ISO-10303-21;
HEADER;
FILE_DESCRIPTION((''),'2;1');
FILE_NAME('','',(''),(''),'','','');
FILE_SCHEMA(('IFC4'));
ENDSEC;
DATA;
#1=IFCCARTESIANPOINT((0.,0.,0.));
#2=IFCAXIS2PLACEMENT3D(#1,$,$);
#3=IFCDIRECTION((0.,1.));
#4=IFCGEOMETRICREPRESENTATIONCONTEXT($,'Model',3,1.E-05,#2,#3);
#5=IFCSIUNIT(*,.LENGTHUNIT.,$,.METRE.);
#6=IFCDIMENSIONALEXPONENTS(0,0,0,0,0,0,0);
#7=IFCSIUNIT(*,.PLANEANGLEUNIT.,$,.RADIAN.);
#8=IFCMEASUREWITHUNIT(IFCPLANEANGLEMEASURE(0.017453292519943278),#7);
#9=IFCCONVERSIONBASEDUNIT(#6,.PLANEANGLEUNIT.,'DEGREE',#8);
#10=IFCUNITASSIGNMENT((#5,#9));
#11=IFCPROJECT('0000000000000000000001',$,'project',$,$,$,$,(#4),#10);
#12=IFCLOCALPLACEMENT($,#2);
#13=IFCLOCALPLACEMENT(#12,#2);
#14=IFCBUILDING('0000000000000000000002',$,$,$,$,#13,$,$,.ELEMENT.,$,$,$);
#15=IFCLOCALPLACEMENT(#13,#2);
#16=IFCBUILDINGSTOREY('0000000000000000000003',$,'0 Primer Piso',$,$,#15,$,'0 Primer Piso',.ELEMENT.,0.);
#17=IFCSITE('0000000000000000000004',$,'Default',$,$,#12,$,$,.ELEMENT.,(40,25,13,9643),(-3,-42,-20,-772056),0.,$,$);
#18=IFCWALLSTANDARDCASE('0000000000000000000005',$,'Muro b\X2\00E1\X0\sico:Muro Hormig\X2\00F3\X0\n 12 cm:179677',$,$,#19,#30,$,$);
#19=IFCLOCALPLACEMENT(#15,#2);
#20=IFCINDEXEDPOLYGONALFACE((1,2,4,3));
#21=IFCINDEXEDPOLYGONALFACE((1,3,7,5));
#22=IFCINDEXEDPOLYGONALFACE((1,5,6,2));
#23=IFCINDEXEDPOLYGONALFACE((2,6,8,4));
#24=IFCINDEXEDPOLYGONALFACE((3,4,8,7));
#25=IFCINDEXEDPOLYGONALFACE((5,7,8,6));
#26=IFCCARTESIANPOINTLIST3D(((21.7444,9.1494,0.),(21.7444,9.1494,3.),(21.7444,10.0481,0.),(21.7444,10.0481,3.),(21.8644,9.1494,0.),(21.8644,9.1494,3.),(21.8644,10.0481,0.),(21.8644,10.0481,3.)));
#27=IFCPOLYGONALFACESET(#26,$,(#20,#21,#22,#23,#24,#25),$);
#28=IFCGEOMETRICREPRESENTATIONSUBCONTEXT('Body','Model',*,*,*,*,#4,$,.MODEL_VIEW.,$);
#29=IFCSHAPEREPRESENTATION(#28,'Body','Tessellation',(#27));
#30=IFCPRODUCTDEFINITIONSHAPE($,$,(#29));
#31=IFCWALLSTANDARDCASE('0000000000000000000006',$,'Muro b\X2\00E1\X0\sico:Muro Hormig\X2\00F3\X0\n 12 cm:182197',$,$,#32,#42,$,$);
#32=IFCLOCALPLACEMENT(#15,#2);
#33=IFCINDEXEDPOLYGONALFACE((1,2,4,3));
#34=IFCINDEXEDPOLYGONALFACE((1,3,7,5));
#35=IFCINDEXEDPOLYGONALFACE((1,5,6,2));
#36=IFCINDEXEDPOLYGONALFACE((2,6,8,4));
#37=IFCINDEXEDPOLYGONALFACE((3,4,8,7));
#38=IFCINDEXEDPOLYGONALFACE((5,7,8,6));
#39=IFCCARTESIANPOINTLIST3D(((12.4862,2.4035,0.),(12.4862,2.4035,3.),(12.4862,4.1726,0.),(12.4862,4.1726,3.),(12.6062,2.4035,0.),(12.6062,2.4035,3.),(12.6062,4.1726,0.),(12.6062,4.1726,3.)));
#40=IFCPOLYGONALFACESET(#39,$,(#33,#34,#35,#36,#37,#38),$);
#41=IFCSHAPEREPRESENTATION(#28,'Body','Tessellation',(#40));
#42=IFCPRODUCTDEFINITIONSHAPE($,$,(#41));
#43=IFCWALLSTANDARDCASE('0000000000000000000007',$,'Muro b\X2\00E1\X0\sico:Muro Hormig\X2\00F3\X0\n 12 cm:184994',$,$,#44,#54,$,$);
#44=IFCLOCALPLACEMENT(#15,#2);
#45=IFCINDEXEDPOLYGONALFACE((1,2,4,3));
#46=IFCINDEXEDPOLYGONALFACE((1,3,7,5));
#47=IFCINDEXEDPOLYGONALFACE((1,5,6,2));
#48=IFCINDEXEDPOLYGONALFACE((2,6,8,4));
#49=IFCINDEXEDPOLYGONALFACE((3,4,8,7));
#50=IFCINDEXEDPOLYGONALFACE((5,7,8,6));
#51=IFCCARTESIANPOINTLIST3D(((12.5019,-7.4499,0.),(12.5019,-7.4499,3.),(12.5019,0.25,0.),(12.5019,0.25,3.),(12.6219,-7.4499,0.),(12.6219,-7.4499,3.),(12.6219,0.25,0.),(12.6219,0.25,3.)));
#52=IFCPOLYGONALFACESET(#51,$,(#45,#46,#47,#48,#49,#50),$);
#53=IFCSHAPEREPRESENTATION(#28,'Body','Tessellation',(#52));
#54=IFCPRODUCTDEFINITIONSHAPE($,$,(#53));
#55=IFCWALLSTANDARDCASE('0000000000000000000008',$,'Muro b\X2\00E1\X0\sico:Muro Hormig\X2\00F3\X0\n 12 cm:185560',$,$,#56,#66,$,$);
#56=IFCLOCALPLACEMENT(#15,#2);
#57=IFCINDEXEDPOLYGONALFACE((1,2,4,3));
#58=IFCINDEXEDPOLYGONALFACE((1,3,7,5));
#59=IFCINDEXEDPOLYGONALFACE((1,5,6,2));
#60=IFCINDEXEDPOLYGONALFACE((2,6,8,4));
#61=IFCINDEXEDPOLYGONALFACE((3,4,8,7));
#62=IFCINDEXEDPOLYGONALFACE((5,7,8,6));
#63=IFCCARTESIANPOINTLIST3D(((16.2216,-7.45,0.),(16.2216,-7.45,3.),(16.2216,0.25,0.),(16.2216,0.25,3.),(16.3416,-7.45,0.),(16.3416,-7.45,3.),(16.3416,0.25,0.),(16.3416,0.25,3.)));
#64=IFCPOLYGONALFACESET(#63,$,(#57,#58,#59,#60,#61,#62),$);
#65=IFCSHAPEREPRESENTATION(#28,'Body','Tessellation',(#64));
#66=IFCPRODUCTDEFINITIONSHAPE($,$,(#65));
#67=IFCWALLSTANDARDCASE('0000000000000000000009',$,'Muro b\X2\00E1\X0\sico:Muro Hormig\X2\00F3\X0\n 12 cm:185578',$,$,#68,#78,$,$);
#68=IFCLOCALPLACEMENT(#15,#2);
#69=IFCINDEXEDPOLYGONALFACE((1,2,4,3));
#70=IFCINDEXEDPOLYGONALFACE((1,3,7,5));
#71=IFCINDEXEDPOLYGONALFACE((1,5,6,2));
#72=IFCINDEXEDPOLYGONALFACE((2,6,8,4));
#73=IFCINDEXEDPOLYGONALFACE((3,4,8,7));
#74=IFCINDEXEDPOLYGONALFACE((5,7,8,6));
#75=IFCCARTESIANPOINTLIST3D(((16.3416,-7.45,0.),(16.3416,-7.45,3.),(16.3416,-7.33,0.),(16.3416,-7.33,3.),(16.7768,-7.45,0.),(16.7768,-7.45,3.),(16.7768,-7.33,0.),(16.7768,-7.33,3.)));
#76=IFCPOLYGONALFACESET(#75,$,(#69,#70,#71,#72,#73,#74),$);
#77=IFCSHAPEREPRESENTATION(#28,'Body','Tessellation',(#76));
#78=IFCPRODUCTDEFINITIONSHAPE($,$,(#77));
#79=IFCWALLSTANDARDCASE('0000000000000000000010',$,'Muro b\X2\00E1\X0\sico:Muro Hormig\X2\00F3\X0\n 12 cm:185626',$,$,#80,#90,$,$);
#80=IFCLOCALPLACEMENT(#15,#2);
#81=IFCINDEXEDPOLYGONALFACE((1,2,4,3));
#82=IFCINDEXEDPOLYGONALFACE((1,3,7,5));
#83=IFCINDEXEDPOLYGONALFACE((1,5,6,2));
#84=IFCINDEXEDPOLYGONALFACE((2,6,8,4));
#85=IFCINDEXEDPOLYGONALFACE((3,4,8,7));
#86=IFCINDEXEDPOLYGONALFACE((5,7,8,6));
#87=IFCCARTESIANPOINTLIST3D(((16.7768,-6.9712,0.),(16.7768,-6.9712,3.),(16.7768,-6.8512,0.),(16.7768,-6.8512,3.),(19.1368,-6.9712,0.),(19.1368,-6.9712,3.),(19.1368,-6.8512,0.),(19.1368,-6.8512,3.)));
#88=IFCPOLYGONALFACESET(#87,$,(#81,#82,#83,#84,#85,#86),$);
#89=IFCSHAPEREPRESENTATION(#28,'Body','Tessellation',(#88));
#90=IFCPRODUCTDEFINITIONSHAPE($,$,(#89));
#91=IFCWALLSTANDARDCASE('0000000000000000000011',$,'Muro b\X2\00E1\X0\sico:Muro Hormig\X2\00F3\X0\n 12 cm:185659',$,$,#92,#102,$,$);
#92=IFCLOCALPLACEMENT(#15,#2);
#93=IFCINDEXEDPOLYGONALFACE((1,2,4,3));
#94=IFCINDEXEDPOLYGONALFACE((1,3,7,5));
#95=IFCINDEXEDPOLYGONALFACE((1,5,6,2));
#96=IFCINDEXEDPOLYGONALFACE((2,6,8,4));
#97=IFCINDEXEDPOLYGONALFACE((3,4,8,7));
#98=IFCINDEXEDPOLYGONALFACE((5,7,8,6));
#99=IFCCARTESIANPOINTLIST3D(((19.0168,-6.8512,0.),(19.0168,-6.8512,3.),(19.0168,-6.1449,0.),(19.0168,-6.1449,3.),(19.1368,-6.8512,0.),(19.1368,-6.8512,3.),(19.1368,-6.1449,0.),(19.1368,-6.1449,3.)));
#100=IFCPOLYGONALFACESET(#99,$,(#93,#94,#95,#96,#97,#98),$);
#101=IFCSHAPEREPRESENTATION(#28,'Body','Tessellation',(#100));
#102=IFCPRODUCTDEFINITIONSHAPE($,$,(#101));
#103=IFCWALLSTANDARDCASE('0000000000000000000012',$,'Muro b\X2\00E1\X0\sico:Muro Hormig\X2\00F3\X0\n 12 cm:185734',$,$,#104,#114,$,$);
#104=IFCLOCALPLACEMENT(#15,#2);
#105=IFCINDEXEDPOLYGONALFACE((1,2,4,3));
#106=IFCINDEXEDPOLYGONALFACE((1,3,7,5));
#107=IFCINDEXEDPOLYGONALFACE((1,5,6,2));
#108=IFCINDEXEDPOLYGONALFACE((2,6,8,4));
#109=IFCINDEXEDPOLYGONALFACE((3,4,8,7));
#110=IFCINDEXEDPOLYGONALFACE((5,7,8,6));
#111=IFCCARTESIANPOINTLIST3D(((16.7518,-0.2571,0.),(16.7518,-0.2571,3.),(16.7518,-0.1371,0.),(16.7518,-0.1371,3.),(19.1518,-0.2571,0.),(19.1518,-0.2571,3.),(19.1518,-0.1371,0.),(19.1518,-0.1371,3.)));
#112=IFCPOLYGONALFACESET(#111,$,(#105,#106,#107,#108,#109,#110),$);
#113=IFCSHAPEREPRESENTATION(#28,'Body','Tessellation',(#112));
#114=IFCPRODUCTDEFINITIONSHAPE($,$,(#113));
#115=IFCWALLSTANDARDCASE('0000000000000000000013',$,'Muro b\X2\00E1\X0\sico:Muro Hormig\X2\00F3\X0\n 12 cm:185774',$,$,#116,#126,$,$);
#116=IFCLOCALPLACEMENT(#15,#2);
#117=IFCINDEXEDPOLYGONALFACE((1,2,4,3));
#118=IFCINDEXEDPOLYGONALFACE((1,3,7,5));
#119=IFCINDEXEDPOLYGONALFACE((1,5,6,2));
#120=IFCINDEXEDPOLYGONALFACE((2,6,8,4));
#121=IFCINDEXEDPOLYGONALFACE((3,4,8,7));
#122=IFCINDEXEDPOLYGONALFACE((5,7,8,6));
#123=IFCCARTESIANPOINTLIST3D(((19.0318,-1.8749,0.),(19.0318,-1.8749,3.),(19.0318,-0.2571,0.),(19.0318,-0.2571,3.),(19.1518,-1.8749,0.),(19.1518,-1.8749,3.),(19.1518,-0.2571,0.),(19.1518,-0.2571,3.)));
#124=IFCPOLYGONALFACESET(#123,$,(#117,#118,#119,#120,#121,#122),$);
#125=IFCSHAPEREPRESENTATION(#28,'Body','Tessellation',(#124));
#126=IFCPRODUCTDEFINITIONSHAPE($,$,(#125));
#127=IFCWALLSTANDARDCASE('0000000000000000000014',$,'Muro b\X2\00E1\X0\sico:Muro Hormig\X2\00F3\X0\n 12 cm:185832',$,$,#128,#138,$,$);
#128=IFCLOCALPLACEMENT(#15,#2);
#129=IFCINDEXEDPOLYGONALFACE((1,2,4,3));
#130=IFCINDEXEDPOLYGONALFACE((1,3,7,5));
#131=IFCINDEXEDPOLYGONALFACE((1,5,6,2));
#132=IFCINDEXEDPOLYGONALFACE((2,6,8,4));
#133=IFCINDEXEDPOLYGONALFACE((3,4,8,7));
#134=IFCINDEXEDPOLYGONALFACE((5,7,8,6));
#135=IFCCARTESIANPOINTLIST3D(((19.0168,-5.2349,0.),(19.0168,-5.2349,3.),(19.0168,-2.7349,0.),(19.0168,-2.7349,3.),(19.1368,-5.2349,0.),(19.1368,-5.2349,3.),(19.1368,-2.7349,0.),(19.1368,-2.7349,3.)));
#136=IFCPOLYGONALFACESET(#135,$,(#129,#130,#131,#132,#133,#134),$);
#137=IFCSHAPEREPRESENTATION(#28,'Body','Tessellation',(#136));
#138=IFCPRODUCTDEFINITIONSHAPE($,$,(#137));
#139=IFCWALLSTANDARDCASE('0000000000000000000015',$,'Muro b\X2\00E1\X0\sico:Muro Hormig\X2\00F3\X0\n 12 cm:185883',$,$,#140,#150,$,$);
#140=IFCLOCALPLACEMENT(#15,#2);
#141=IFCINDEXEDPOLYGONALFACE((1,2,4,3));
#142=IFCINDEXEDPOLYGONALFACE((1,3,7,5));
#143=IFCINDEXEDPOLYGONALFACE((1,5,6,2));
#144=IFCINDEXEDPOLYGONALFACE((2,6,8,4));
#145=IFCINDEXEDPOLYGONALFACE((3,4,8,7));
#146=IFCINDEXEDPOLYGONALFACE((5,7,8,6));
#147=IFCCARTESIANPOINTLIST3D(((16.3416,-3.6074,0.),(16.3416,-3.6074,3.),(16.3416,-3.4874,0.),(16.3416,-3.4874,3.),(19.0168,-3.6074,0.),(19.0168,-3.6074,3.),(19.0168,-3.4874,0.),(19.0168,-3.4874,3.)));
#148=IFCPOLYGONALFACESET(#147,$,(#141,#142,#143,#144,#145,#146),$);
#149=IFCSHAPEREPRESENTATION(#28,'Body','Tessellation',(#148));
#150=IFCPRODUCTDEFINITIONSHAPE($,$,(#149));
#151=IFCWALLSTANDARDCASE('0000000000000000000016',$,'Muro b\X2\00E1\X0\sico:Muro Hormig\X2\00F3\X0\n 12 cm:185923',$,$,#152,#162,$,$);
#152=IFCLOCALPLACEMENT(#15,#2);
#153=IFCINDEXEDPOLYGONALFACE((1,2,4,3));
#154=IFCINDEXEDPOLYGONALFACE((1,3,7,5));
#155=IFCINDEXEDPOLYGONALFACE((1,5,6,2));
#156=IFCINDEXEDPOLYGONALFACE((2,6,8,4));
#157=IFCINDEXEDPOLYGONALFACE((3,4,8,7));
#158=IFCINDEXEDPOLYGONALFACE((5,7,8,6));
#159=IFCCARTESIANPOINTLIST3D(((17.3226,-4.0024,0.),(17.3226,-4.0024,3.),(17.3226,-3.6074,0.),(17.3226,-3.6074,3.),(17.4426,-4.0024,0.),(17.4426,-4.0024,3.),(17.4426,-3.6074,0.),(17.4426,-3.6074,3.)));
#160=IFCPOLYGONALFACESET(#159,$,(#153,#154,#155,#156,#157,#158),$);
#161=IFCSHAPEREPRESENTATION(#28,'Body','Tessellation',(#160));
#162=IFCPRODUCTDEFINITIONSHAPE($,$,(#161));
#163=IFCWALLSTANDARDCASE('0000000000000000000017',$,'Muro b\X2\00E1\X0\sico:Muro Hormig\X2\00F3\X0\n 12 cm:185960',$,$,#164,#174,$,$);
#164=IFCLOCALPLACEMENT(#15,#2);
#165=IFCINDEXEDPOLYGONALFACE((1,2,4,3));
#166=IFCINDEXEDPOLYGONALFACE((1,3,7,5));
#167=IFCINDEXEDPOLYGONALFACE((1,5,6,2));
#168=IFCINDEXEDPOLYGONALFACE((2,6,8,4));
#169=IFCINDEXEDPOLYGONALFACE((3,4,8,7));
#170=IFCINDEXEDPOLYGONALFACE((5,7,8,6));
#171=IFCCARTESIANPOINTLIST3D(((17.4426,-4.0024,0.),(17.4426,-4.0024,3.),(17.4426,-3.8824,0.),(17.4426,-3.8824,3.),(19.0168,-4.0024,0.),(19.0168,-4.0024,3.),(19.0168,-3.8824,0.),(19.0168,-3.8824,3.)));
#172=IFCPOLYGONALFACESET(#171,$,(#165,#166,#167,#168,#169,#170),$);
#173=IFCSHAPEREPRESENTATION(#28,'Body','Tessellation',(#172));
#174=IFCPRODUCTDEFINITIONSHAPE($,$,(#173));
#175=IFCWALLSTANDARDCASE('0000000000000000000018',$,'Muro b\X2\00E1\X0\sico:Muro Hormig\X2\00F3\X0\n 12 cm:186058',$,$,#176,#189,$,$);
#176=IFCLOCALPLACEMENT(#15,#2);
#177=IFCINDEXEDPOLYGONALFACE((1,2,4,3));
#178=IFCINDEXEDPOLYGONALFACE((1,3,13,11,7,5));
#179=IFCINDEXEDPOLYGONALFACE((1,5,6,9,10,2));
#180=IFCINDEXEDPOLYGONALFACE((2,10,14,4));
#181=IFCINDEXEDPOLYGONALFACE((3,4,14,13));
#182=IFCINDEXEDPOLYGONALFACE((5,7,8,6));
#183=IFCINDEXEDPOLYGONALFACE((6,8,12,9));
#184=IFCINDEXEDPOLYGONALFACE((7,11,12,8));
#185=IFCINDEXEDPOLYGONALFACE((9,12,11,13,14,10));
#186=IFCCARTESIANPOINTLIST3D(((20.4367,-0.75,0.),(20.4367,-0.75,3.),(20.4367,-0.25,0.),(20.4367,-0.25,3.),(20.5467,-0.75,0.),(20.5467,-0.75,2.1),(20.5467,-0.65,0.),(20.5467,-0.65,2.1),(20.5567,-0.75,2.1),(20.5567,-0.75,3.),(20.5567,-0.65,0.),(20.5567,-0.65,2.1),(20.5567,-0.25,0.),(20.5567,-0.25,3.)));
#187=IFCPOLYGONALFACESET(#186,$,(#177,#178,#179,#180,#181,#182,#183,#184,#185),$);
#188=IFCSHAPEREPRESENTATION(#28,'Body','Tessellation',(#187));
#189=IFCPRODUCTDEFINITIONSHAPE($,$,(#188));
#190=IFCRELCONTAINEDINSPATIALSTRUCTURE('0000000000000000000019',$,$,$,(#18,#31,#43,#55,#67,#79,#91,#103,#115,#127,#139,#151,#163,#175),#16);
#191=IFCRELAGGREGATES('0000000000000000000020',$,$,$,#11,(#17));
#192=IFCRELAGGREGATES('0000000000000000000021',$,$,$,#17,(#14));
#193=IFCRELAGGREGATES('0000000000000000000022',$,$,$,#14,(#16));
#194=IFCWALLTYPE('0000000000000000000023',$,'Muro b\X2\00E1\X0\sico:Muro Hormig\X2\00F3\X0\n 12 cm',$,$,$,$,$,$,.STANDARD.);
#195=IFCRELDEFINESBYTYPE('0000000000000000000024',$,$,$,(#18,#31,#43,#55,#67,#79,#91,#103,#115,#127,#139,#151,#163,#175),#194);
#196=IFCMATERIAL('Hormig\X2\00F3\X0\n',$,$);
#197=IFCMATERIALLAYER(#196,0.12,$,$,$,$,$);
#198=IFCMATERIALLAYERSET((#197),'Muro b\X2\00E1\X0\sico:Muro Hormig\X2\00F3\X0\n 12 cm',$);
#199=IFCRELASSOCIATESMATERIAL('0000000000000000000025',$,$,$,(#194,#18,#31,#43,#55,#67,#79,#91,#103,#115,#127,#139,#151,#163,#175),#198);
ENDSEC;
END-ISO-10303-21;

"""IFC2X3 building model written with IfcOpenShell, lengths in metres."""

from ifc_helpers import new_model, entity, si_unit, converted_unit, direction, frame, frame_2d, origin, place, context, subcontext, project, spatial, rectangle, extrude, material, layer, layer_set, layer_usage, type_object, element, save


model = new_model("IFC2X3")

# Units and contexts
model_context = context("Model", 3, precision=1e-05, world=origin(), true_north=direction((0.0, 1.0)))
body_context = subcontext(model_context, "Body", "Model", "MODEL_VIEW")
ifc_project = project(units=[si_unit("LENGTHUNIT", "METRE"), converted_unit("PLANEANGLEUNIT", "DEGREE", entity("IfcPlaneAngleMeasure", 0.017453292519943278), si_unit("PLANEANGLEUNIT", "RADIAN"), dimensions=[0, 0, 0, 0, 0, 0, 0])], contexts=[model_context])

# Site, building, storey
site_placement = place(None, origin())
site = spatial("IfcSite", under=ifc_project, at=site_placement, Name="Default", CompositionType="ELEMENT", RefLatitude=(40, 25, 13, 9643), RefLongitude=(-3, -42, -20, -772056), RefElevation=0.0)
building_placement = place(site_placement, origin())
building = spatial("IfcBuilding", under=site, at=building_placement, CompositionType="ELEMENT")
storey_placement = place(building_placement, origin())
storey = spatial("IfcBuildingStorey", under=building, at=storey_placement, Name="0 Primer Piso", LongName="0 Primer Piso", CompositionType="ELEMENT", Elevation=0.0)

# Walls
ifc_material = material(Name="Hormigón")
ifc_layer = layer(ifc_material, 0.12)
ifc_layer_set = layer_set([ifc_layer], Name="Muro básico:Muro Hormigón 12 cm")
ifc_layer_usage_1 = layer_usage(ifc_layer_set, "AXIS2", "NEGATIVE", 0.06)
wall_type = type_object("IfcWallType", Name="Muro básico:Muro Hormigón 12 cm", PredefinedType="STANDARD", material=ifc_layer_set)
wall_1_placement = place(storey_placement, frame((21.8044, 9.1494, 0.0), z_axis=(0.0, 0.0, 1.0), x_axis=(0.0, 1.0, 0.0)))
element("IfcWallStandardCase", 1, at=wall_1_placement, inside=storey, type_object=wall_type, material=ifc_layer_usage_1, Name="Muro básico:Muro Hormigón 12 cm:179677", context=body_context, shape_type="SweptSolid", body=[
    extrude(rectangle(XDim=0.8988, YDim=0.12, at=frame_2d((0.4494, 0.0), x_axis=(-1.0, 0.0))), origin(), (0.0, 0.0, 1.0), 3.0),
])
ifc_layer_usage_2 = layer_usage(ifc_layer_set, "AXIS2", "NEGATIVE", 0.06)
wall_2_placement = place(storey_placement, frame((12.5462, 4.1726, 0.0), z_axis=(0.0, 0.0, 1.0), x_axis=(0.0, -1.0, 0.0)))
element("IfcWallStandardCase", 2, at=wall_2_placement, inside=storey, type_object=wall_type, material=ifc_layer_usage_2, Name="Muro básico:Muro Hormigón 12 cm:182197", context=body_context, shape_type="SweptSolid", body=[
    extrude(rectangle(XDim=1.7691, YDim=0.12, at=frame_2d((0.8846, 0.0), x_axis=(-1.0, 0.0))), origin(), (0.0, 0.0, 1.0), 3.0),
])
ifc_layer_usage_3 = layer_usage(ifc_layer_set, "AXIS2", "NEGATIVE", 0.06)
wall_3_placement = place(storey_placement, frame((12.5619, 0.25, 0.0), z_axis=(0.0, 0.0, 1.0), x_axis=(0.0, -1.0, 0.0)))
element("IfcWallStandardCase", 3, at=wall_3_placement, inside=storey, type_object=wall_type, material=ifc_layer_usage_3, Name="Muro básico:Muro Hormigón 12 cm:184994", context=body_context, shape_type="SweptSolid", body=[
    extrude(rectangle(XDim=7.6999, YDim=0.12, at=frame_2d((3.85, 0.0), x_axis=(-1.0, 0.0))), origin(), (0.0, 0.0, 1.0), 3.0),
])
ifc_layer_usage_4 = layer_usage(ifc_layer_set, "AXIS2", "NEGATIVE", 0.06)
wall_4_placement = place(storey_placement, frame((16.2816, 0.25, 0.0), z_axis=(0.0, 0.0, 1.0), x_axis=(0.0, -1.0, 0.0)))
element("IfcWallStandardCase", 4, at=wall_4_placement, inside=storey, type_object=wall_type, material=ifc_layer_usage_4, Name="Muro básico:Muro Hormigón 12 cm:185560", context=body_context, shape_type="SweptSolid", body=[
    extrude(rectangle(XDim=7.7, YDim=0.12, at=frame_2d((3.85, 0.0), x_axis=(-1.0, 0.0))), origin(), (0.0, 0.0, 1.0), 3.0),
])
ifc_layer_usage_5 = layer_usage(ifc_layer_set, "AXIS2", "NEGATIVE", 0.06)
wall_5_placement = place(storey_placement, frame((16.3416, -7.39, 0.0)))
element("IfcWallStandardCase", 5, at=wall_5_placement, inside=storey, type_object=wall_type, material=ifc_layer_usage_5, Name="Muro básico:Muro Hormigón 12 cm:185578", context=body_context, shape_type="SweptSolid", body=[
    extrude(rectangle(XDim=0.4351, YDim=0.12, at=frame_2d((0.2176, 0.0), x_axis=(-1.0, 0.0))), origin(), (0.0, 0.0, 1.0), 3.0),
])
ifc_layer_usage_6 = layer_usage(ifc_layer_set, "AXIS2", "NEGATIVE", 0.06)
wall_6_placement = place(storey_placement, frame((16.7768, -6.9112, 0.0)))
element("IfcWallStandardCase", 6, at=wall_6_placement, inside=storey, type_object=wall_type, material=ifc_layer_usage_6, Name="Muro básico:Muro Hormigón 12 cm:185626", context=body_context, shape_type="SweptSolid", body=[
    extrude(rectangle(XDim=2.36, YDim=0.12, at=frame_2d((1.18, 0.0), x_axis=(-1.0, 0.0))), origin(), (0.0, 0.0, 1.0), 3.0),
])
ifc_layer_usage_7 = layer_usage(ifc_layer_set, "AXIS2", "NEGATIVE", 0.06)
wall_7_placement = place(storey_placement, frame((19.0768, -6.8512, 0.0), z_axis=(0.0, 0.0, 1.0), x_axis=(0.0, 1.0, 0.0)))
element("IfcWallStandardCase", 7, at=wall_7_placement, inside=storey, type_object=wall_type, material=ifc_layer_usage_7, Name="Muro básico:Muro Hormigón 12 cm:185659", context=body_context, shape_type="SweptSolid", body=[
    extrude(rectangle(XDim=0.7063, YDim=0.12, at=frame_2d((0.3531, 0.0), x_axis=(-1.0, 0.0))), origin(), (0.0, 0.0, 1.0), 3.0),
])
ifc_layer_usage_8 = layer_usage(ifc_layer_set, "AXIS2", "NEGATIVE", 0.06)
wall_8_placement = place(storey_placement, frame((16.7518, -0.1971, 0.0)))
element("IfcWallStandardCase", 8, at=wall_8_placement, inside=storey, type_object=wall_type, material=ifc_layer_usage_8, Name="Muro básico:Muro Hormigón 12 cm:185734", context=body_context, shape_type="SweptSolid", body=[
    extrude(rectangle(XDim=2.4, YDim=0.12, at=frame_2d((1.2, 0.0), x_axis=(-1.0, 0.0))), origin(), (0.0, 0.0, 1.0), 3.0),
])
ifc_layer_usage_9 = layer_usage(ifc_layer_set, "AXIS2", "NEGATIVE", 0.06)
wall_9_placement = place(storey_placement, frame((19.0918, -0.2571, 0.0), z_axis=(0.0, 0.0, 1.0), x_axis=(0.0, -1.0, 0.0)))
element("IfcWallStandardCase", 9, at=wall_9_placement, inside=storey, type_object=wall_type, material=ifc_layer_usage_9, Name="Muro básico:Muro Hormigón 12 cm:185774", context=body_context, shape_type="SweptSolid", body=[
    extrude(rectangle(XDim=1.6178, YDim=0.12, at=frame_2d((0.8089, 0.0), x_axis=(-1.0, 0.0))), origin(), (0.0, 0.0, 1.0), 3.0),
])
ifc_layer_usage_10 = layer_usage(ifc_layer_set, "AXIS2", "NEGATIVE", 0.06)
wall_10_placement = place(storey_placement, frame((19.0768, -2.7349, 0.0), z_axis=(0.0, 0.0, 1.0), x_axis=(0.0, -1.0, 0.0)))
element("IfcWallStandardCase", 10, at=wall_10_placement, inside=storey, type_object=wall_type, material=ifc_layer_usage_10, Name="Muro básico:Muro Hormigón 12 cm:185832", context=body_context, shape_type="SweptSolid", body=[
    extrude(rectangle(XDim=2.5, YDim=0.12, at=frame_2d((1.25, 0.0), x_axis=(-1.0, 0.0))), origin(), (0.0, 0.0, 1.0), 3.0),
])
ifc_layer_usage_11 = layer_usage(ifc_layer_set, "AXIS2", "NEGATIVE", 0.06)
wall_11_placement = place(storey_placement, frame((19.0168, -3.5474, 0.0), z_axis=(0.0, 0.0, 1.0), x_axis=(-1.0, 0.0, 0.0)))
element("IfcWallStandardCase", 11, at=wall_11_placement, inside=storey, type_object=wall_type, material=ifc_layer_usage_11, Name="Muro básico:Muro Hormigón 12 cm:185883", context=body_context, shape_type="SweptSolid", body=[
    extrude(rectangle(XDim=2.6751, YDim=0.12, at=frame_2d((1.3376, 0.0), x_axis=(-1.0, 0.0))), origin(), (0.0, 0.0, 1.0), 3.0),
])
ifc_layer_usage_12 = layer_usage(ifc_layer_set, "AXIS2", "NEGATIVE", 0.06)
wall_12_placement = place(storey_placement, frame((17.3826, -3.6074, 0.0), z_axis=(0.0, 0.0, 1.0), x_axis=(0.0, -1.0, 0.0)))
element("IfcWallStandardCase", 12, at=wall_12_placement, inside=storey, type_object=wall_type, material=ifc_layer_usage_12, Name="Muro básico:Muro Hormigón 12 cm:185923", context=body_context, shape_type="SweptSolid", body=[
    extrude(rectangle(XDim=0.395, YDim=0.12, at=frame_2d((0.1975, 0.0), x_axis=(-1.0, 0.0))), origin(), (0.0, 0.0, 1.0), 3.0),
])
ifc_layer_usage_13 = layer_usage(ifc_layer_set, "AXIS2", "NEGATIVE", 0.06)
wall_13_placement = place(storey_placement, frame((17.4426, -3.9424, 0.0)))
element("IfcWallStandardCase", 13, at=wall_13_placement, inside=storey, type_object=wall_type, material=ifc_layer_usage_13, Name="Muro básico:Muro Hormigón 12 cm:185960", context=body_context, shape_type="SweptSolid", body=[
    extrude(rectangle(XDim=1.5742, YDim=0.12, at=frame_2d((0.7871, 0.0), x_axis=(-1.0, 0.0))), origin(), (0.0, 0.0, 1.0), 3.0),
])

# Wall, opening
ifc_layer_usage_14 = layer_usage(ifc_layer_set, "AXIS2", "NEGATIVE", 0.06)
wall_14_placement = place(storey_placement, frame((20.4967, -0.25, 0.0), z_axis=(0.0, 0.0, 1.0), x_axis=(0.0, -1.0, 0.0)))
wall_14 = element("IfcWallStandardCase", 14, at=wall_14_placement, inside=storey, type_object=wall_type, material=ifc_layer_usage_14, Name="Muro básico:Muro Hormigón 12 cm:186058", context=body_context, shape_type="SweptSolid", body=[
    extrude(rectangle(XDim=0.5, YDim=0.12, at=frame_2d((0.25, 0.0), x_axis=(-1.0, 0.0))), origin(), (0.0, 0.0, 1.0), 3.0),
])
opening_1_placement = place(wall_14_placement, origin())
element("IfcOpeningElement", 15, at=opening_1_placement, cuts=wall_14, ObjectType="Opening", context=body_context, shape_type="SweptSolid", body=[
    extrude(rectangle(XDim=2.1, YDim=0.12, at=frame_2d((0.0, 0.0), x_axis=(0.0, 1.0))), frame((0.46, 0.05, 1.05), z_axis=(0.0, 1.0, 0.0), x_axis=(1.0, 0.0, 0.0)), (0.0, 0.0, 1.0), 0.9),
])

save(model, "model.ifc")
